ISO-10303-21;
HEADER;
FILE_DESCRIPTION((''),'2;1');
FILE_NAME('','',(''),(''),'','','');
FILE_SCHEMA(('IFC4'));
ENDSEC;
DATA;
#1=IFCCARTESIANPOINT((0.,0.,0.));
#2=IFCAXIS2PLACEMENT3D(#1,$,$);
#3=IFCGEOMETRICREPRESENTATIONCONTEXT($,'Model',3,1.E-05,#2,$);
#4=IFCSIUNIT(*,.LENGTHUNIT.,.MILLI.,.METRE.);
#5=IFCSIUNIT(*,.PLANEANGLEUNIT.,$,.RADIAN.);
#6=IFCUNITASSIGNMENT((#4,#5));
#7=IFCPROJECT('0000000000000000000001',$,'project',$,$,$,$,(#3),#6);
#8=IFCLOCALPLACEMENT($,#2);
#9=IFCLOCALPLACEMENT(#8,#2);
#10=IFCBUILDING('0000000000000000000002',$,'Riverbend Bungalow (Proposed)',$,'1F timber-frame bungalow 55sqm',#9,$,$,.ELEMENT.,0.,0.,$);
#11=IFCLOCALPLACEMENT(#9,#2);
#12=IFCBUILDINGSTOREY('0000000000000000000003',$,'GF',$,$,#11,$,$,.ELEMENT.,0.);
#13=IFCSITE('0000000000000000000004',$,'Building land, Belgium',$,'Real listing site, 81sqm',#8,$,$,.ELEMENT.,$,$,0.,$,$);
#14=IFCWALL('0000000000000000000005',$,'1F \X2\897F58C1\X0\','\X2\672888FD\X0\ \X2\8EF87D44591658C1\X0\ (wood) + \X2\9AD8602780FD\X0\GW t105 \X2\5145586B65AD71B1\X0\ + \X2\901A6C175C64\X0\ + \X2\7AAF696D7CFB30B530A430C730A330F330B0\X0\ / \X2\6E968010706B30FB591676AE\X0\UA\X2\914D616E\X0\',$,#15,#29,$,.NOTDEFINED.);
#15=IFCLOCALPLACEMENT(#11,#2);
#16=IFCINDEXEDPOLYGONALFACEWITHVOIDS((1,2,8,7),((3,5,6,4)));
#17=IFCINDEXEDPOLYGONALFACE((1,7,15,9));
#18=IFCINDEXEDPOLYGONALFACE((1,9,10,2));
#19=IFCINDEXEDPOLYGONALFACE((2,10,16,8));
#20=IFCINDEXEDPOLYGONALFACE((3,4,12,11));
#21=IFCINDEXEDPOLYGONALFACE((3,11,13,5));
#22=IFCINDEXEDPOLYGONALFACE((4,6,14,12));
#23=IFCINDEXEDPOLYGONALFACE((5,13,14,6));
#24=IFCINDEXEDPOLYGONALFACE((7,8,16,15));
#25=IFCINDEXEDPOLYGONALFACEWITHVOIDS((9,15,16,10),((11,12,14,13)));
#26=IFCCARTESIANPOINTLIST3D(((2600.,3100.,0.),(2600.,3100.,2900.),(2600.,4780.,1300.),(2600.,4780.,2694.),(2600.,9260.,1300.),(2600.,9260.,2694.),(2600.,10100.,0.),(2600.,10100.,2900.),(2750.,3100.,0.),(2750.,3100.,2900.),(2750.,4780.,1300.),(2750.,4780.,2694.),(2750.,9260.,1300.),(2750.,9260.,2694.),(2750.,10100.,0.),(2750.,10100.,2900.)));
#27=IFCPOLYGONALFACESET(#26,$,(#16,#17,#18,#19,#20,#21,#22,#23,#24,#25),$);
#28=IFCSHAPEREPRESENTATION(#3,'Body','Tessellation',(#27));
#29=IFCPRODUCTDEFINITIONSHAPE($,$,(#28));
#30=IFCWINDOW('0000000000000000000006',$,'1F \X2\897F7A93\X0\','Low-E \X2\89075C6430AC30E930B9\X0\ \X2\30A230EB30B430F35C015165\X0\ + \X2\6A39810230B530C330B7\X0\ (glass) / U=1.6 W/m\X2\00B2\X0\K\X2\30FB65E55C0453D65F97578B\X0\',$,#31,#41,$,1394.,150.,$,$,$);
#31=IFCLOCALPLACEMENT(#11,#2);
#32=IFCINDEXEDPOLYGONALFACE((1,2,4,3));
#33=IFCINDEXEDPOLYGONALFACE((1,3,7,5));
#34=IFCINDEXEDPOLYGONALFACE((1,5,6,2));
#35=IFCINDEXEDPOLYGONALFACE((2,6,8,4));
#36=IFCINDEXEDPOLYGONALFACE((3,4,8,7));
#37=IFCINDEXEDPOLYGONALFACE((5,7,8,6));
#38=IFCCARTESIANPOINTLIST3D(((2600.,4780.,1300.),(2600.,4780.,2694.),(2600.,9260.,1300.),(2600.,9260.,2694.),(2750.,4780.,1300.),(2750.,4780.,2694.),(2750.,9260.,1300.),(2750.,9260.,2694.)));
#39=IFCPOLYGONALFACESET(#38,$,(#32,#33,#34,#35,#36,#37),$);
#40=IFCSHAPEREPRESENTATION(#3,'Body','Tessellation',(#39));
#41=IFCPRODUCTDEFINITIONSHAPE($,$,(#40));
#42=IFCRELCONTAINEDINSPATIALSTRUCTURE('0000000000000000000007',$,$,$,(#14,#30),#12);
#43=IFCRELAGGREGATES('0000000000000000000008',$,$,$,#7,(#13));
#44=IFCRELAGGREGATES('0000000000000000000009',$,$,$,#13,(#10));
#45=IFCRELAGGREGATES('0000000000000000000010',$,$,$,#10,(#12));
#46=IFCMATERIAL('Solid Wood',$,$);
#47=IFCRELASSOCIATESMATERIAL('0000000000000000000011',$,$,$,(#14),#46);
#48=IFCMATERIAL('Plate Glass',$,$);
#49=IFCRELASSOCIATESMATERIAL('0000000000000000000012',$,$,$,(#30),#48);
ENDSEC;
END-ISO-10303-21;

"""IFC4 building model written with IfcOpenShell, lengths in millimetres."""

from ifc_helpers import new_model, si_unit, frame, frame_2d, origin, place, context, project, spatial, rectangle, extrude, material, element, fill, save


model = new_model("IFC4")

# Units and contexts
model_context = context("Model", 3, precision=1e-05, world=origin())
ifc_project = project(units=[si_unit("LENGTHUNIT", "METRE", prefix="MILLI"), si_unit("PLANEANGLEUNIT", "RADIAN")], contexts=[model_context])

# Site, building, storey
site_placement = place(None, origin())
site = spatial("IfcSite", under=ifc_project, at=site_placement, Name="Building land, Belgium", ObjectType="Real listing site, 81sqm", CompositionType="ELEMENT", RefElevation=0.0)
building_placement = place(site_placement, origin())
building = spatial("IfcBuilding", under=site, at=building_placement, Name="Riverbend Bungalow (Proposed)", ObjectType="1F timber-frame bungalow 55sqm", CompositionType="ELEMENT", ElevationOfRefHeight=0.0, ElevationOfTerrain=0.0)
storey_placement = place(building_placement, origin())
storey = spatial("IfcBuildingStorey", under=building, at=storey_placement, Name="GF", CompositionType="ELEMENT", Elevation=0.0)

# Shared definitions
ifc_material_1 = material(Name="Solid Wood")

# Shared definitions
ifc_material_2 = material(Name="Plate Glass")

# Wall, opening, window
wall_1_placement = place(storey_placement, frame((1300.0, 1550.0, 0.0)))
wall_1 = element("IfcWall", 1, at=wall_1_placement, inside=storey, material=ifc_material_1, Name="1F 西壁", Description="木製 軸組外壁 (wood) + 高性能GW t105 充填断熱 + 通気層 + 窯業系サイディング / 準耐火・外皮UA配慮", PredefinedType="NOTDEFINED", context=model_context, shape_type="SweptSolid", body=[
    extrude(rectangle(XDim=150.0, YDim=7000.0, at=frame_2d((75.0, 3500.0))), frame((1300.0, 1550.0, 0.0)), (0.0, 0.0, 1.0), 2900.0),
])
opening_1_placement = place(storey_placement, frame((1300.0, 2390.0, 650.0)))
opening_1 = element("IfcOpeningElement", 2, at=opening_1_placement, cuts=wall_1, PredefinedType="NOTDEFINED", context=model_context, shape_type="SweptSolid", body=[
    extrude(rectangle(XDim=150.0, YDim=4480.0, at=frame_2d((75.0, 2240.0))), frame((1300.0, 2390.0, 650.0)), (0.0, 0.0, 1.0), 1394.0),
])
window_1_placement = place(storey_placement, frame((1300.0, 2390.0, 650.0)))
window_1 = element("IfcWindow", 3, at=window_1_placement, inside=storey, material=ifc_material_2, Name="1F 西窓", Description="Low-E 複層ガラス アルゴン封入 + 樹脂サッシ (glass) / U=1.6 W/m²K・日射取得型", OverallHeight=1394.0, OverallWidth=150.0, context=model_context, shape_type="SweptSolid", body=[
    extrude(rectangle(XDim=150.0, YDim=4480.0, at=frame_2d((75.0, 2240.0))), frame((1300.0, 2390.0, 650.0)), (0.0, 0.0, 1.0), 1394.0),
])
fill(opening_1, window_1)

save(model, "model.ifc")
